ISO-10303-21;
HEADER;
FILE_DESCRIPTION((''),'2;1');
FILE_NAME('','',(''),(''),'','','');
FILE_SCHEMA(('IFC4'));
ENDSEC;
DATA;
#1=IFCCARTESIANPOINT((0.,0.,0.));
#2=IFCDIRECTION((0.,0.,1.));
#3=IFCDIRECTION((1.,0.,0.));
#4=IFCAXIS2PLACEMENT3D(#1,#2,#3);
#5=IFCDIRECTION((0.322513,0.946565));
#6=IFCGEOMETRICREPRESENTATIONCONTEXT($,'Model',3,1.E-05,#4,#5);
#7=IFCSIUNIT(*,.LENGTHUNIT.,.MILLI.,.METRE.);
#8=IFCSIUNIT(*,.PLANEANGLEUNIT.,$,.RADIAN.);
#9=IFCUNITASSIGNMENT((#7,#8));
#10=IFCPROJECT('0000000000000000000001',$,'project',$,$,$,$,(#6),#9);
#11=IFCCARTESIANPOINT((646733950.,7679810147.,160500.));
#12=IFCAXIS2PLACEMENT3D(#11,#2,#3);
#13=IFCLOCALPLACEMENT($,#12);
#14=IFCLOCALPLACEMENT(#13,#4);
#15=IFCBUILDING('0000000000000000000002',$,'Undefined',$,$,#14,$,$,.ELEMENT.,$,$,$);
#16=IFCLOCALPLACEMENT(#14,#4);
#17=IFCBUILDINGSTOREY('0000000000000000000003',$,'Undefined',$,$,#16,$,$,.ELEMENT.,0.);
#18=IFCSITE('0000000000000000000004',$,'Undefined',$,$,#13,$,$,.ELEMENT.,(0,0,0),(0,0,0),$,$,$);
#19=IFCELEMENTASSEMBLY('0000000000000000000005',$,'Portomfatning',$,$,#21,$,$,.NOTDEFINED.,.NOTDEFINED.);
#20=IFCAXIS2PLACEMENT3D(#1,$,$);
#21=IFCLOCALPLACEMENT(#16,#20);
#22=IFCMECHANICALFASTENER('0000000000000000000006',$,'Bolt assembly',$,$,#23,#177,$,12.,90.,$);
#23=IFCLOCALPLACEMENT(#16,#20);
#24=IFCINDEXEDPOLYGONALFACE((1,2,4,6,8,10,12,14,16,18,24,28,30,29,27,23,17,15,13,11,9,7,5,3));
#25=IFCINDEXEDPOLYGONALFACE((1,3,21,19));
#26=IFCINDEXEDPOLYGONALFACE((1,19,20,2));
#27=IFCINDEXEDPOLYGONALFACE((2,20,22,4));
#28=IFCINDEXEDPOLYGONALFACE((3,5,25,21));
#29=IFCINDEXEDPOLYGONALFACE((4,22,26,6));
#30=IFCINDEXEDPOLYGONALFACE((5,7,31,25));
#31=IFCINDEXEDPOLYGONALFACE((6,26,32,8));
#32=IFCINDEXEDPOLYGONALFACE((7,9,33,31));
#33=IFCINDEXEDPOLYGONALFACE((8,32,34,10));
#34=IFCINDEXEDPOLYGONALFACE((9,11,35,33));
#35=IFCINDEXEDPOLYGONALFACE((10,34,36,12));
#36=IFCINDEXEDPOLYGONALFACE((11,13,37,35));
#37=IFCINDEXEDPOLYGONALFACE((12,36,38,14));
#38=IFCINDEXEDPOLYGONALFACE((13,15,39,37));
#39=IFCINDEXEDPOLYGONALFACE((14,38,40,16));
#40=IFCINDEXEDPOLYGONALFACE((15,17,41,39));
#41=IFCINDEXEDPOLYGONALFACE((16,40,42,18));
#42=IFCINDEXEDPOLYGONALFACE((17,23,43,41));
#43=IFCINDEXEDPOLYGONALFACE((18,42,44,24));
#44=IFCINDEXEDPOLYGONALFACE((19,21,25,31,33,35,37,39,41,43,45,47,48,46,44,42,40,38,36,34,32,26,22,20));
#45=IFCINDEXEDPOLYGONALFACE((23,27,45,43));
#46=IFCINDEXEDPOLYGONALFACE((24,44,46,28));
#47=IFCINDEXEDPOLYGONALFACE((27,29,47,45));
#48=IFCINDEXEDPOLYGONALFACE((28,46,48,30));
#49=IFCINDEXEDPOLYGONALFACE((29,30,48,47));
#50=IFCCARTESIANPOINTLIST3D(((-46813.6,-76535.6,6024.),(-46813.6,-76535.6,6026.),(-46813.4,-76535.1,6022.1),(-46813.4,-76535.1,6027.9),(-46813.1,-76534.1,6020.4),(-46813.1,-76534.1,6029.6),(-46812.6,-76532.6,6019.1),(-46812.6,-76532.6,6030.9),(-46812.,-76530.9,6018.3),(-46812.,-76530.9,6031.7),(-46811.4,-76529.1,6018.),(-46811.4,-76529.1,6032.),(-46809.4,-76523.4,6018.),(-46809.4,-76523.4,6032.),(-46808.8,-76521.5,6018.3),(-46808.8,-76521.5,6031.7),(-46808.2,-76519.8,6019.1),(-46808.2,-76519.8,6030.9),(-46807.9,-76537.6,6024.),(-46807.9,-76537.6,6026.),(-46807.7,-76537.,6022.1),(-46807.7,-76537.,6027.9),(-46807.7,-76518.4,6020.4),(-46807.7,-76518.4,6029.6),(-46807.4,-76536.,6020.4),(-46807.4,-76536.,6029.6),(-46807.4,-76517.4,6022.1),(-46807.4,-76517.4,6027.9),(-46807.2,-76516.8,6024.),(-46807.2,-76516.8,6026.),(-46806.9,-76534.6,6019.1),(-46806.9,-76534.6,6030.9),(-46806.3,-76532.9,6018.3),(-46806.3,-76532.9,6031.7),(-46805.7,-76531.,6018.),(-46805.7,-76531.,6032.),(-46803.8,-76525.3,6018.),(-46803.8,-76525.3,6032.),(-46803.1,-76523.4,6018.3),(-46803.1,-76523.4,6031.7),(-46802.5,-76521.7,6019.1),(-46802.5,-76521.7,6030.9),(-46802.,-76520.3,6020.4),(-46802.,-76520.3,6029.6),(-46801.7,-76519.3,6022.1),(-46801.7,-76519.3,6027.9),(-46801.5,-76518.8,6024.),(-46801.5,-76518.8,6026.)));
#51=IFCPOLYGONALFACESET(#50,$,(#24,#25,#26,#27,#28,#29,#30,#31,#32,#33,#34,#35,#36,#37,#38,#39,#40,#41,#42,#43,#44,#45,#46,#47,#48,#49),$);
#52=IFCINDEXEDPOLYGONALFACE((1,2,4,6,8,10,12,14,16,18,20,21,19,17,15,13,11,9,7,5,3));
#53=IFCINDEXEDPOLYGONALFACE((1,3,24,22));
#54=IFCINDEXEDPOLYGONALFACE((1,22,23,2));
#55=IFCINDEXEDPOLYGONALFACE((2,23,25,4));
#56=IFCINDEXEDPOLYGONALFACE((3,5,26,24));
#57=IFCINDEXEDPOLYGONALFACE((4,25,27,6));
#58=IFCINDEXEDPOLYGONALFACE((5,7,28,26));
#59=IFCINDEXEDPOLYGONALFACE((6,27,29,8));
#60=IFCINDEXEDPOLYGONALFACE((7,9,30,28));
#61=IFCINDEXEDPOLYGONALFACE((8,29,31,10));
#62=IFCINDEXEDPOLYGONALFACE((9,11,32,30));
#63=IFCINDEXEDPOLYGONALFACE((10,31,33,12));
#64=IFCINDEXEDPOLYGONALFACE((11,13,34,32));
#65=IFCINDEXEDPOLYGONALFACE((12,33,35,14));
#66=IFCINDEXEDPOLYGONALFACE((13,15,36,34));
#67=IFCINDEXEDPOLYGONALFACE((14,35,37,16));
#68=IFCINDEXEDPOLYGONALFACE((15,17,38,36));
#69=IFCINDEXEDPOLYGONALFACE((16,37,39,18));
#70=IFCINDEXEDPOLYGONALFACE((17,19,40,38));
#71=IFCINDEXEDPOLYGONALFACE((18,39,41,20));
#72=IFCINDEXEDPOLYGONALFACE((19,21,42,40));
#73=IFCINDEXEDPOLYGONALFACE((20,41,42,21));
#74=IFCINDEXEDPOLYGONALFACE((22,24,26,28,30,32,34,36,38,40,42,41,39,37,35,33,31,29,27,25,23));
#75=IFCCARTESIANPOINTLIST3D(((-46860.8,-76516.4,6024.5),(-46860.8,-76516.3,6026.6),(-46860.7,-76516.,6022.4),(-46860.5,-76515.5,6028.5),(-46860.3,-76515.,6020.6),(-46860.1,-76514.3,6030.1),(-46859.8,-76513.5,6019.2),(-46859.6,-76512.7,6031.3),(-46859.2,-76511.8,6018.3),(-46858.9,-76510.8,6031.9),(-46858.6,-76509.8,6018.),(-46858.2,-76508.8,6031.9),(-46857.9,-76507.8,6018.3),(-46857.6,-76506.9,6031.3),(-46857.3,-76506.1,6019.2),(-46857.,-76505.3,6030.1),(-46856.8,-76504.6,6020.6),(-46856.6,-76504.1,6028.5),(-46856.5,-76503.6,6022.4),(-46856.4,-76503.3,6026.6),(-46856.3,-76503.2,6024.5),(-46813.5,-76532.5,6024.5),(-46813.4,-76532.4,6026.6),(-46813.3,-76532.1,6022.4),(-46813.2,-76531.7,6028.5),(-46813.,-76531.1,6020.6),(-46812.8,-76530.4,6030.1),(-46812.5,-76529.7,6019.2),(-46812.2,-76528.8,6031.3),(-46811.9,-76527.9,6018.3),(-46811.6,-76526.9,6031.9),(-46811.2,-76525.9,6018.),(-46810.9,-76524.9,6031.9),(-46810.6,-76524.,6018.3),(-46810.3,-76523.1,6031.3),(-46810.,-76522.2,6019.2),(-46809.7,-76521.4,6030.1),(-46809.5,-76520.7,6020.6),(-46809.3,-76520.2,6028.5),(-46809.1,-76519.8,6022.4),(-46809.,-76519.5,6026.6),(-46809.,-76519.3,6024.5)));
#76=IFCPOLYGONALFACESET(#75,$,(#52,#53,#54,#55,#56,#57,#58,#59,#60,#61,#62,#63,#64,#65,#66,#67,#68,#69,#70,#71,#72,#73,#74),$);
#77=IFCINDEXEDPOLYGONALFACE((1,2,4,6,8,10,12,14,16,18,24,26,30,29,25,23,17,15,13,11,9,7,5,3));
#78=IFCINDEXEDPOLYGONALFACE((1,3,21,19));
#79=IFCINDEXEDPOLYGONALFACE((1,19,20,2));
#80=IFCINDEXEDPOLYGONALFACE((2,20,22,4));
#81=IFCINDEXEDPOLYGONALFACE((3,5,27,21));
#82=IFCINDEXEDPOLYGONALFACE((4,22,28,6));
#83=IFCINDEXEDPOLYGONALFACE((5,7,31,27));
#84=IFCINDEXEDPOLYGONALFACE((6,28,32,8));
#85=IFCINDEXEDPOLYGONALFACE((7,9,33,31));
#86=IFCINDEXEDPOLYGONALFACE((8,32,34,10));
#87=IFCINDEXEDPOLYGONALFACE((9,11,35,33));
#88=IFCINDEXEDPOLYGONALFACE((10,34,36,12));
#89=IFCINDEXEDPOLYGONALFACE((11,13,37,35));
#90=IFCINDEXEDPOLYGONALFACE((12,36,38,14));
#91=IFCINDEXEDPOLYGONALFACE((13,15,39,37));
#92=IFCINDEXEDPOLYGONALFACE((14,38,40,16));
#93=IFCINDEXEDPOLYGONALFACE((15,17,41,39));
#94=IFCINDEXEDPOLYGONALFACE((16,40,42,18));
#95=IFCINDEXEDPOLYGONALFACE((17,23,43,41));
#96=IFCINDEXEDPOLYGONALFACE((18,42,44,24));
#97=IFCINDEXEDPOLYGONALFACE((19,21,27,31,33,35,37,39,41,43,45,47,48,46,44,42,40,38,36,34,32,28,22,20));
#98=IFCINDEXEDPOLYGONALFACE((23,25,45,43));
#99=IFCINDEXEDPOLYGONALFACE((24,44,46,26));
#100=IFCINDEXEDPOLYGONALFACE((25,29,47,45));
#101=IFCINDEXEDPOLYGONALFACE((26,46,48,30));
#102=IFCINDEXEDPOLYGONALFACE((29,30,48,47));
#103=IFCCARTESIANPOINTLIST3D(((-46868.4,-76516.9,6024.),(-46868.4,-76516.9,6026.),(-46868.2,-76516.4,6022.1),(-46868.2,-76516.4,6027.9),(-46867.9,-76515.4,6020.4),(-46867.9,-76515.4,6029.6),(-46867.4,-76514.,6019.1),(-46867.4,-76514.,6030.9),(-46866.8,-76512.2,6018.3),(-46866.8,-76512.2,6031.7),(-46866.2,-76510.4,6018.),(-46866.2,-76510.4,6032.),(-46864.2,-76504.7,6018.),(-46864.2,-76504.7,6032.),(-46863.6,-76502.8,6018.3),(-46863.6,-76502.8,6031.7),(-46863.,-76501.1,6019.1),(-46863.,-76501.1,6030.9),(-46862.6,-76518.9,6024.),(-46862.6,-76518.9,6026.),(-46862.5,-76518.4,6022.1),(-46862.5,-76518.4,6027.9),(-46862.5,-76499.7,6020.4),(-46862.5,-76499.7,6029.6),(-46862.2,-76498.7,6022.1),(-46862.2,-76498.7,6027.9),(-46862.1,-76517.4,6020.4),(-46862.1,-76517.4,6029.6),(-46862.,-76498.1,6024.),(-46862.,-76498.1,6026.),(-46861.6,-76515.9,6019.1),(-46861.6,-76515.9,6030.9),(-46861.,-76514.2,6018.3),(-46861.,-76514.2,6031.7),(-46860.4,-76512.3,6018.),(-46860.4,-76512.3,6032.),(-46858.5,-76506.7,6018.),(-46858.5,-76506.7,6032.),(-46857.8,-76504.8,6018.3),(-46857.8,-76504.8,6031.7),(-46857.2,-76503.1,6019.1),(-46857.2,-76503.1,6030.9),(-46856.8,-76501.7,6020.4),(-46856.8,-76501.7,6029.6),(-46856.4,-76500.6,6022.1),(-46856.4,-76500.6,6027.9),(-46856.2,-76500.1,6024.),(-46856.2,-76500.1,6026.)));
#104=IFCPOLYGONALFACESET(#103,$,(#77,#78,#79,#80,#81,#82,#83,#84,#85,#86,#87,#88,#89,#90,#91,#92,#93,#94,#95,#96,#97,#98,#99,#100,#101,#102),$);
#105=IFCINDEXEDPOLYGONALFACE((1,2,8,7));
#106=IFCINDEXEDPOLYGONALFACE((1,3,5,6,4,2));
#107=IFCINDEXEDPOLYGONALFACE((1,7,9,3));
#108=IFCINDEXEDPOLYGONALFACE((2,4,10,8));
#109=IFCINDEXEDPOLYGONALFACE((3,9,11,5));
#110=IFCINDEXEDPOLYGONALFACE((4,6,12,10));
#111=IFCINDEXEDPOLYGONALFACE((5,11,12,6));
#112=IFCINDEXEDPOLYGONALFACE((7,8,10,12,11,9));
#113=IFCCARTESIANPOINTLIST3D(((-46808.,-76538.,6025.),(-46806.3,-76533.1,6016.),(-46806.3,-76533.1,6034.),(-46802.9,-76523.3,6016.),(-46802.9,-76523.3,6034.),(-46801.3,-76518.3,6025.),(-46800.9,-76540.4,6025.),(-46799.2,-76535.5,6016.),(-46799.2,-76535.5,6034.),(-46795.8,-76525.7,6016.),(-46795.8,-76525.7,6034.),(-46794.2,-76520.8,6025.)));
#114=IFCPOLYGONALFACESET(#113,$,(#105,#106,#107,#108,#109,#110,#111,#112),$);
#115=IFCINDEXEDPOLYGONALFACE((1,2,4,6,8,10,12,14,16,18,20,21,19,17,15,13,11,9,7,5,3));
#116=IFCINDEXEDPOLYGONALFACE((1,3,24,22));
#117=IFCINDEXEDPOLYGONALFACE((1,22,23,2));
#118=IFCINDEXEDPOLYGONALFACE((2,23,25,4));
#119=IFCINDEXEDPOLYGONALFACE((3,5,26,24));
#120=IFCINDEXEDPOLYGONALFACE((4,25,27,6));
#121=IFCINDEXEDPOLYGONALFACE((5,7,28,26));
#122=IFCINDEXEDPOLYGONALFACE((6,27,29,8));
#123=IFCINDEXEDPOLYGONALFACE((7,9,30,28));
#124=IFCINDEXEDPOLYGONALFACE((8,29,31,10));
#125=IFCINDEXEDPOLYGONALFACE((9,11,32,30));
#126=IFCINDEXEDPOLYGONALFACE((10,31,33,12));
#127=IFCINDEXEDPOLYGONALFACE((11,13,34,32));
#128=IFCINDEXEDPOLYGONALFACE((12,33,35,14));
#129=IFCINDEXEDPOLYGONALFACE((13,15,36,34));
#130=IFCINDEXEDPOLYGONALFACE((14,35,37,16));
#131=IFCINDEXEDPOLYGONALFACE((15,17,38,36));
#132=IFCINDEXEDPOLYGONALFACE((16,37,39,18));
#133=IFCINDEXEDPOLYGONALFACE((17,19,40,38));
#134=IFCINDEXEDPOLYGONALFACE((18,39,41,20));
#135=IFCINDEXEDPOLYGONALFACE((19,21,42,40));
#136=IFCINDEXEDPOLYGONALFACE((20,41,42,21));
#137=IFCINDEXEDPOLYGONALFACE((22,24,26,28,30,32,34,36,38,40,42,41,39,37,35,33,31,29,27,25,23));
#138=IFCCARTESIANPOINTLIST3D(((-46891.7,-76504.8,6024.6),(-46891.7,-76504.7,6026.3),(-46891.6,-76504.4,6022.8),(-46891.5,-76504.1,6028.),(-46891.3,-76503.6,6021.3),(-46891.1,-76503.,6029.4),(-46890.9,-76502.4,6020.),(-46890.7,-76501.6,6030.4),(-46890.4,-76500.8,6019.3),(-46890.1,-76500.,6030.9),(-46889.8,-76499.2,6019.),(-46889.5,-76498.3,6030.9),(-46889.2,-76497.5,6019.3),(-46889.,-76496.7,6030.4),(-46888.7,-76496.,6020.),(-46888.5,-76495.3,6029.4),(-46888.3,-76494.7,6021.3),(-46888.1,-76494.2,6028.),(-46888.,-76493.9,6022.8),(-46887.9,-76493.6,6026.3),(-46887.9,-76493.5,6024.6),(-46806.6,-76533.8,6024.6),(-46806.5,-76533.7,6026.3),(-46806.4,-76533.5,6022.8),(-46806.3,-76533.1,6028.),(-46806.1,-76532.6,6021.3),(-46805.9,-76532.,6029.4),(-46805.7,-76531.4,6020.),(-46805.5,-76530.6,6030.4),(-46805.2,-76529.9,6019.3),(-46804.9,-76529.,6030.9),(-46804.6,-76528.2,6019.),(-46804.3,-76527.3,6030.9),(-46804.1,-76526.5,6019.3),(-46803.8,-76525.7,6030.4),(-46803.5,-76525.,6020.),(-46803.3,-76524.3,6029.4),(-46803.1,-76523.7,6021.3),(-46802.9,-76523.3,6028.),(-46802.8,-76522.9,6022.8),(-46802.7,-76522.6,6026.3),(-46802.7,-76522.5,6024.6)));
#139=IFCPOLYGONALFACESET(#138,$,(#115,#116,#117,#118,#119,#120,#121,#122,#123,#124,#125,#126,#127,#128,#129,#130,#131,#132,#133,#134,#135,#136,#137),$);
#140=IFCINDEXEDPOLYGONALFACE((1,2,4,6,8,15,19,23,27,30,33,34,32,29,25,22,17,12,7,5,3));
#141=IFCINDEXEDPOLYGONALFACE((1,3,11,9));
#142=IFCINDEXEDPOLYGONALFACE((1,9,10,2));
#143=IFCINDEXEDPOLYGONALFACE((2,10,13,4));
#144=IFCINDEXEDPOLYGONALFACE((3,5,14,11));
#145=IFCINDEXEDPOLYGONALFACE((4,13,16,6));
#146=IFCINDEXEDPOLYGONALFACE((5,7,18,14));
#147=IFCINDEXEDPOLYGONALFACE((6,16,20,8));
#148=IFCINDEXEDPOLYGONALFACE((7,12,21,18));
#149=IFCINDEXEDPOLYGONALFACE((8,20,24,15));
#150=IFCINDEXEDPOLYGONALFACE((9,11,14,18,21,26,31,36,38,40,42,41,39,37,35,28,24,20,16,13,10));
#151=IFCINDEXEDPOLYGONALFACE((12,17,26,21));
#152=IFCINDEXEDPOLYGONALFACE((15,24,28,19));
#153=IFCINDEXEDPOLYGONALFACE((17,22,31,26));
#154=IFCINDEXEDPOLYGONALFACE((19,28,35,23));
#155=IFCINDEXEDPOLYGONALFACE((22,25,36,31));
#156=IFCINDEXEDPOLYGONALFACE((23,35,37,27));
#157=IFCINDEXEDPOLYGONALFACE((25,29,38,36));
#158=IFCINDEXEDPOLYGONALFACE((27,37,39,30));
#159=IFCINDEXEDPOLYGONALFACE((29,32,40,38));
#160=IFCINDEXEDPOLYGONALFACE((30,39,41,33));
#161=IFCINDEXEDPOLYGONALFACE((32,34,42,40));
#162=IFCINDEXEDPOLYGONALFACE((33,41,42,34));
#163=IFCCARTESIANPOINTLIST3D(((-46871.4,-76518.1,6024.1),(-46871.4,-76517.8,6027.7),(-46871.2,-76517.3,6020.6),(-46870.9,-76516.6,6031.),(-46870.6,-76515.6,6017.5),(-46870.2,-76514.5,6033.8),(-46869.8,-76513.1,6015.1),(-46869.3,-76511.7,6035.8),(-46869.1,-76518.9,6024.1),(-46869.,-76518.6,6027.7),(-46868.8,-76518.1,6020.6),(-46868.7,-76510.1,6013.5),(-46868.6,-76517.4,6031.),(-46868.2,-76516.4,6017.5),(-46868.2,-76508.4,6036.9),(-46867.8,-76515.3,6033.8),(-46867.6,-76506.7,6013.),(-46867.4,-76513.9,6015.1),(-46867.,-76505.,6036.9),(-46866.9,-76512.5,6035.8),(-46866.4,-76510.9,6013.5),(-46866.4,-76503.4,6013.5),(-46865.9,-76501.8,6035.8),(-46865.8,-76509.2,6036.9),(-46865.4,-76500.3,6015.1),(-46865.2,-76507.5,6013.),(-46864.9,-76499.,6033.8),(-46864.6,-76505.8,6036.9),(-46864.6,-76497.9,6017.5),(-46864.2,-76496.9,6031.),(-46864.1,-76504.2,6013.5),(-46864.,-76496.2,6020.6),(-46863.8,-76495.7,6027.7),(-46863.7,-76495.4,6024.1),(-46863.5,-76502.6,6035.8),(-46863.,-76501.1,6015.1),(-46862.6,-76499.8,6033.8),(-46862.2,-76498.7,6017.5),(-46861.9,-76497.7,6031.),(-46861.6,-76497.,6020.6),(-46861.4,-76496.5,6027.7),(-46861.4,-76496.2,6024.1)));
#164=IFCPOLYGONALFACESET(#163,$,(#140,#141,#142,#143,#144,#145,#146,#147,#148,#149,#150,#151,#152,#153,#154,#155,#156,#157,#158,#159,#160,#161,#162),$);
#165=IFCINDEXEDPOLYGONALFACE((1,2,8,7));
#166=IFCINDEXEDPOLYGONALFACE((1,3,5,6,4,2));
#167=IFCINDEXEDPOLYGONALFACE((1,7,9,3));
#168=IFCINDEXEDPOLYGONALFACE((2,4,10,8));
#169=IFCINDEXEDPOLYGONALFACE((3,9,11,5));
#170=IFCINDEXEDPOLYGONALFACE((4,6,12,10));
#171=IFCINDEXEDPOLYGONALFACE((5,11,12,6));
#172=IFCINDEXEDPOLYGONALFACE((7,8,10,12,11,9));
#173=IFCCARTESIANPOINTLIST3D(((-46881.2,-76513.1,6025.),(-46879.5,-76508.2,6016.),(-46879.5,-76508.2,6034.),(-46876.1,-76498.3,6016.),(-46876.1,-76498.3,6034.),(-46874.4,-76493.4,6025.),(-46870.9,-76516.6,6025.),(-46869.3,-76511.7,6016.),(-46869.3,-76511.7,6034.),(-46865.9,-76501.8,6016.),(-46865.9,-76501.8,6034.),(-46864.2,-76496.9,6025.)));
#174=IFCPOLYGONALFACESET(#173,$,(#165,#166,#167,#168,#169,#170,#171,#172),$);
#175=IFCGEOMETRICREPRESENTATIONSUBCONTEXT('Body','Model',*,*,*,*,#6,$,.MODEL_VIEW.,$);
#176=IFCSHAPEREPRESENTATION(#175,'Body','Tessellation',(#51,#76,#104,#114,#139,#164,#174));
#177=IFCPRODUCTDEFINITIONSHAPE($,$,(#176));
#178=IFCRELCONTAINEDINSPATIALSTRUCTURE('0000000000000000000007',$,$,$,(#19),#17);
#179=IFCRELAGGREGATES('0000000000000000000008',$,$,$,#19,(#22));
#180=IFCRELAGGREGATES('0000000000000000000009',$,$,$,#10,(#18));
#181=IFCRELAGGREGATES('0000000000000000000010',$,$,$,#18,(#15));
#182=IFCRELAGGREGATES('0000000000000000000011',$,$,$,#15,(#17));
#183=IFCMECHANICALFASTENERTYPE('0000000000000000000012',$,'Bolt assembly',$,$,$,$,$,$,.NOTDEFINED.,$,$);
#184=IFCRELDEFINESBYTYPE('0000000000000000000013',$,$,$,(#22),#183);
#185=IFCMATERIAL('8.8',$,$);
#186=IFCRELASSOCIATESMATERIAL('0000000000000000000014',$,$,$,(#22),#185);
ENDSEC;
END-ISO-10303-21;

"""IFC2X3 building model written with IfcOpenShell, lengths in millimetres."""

from ifc_helpers import new_model, entity, si_unit, direction, frame, origin_with_axes, origin_2d_with_axis, place, context, subcontext, project, spatial, polyline, circle, outline, extrude, source, transform, mapped, material, type_object, element, aggregate, save


model = new_model("IFC2X3")

# Units and contexts
model_context = context("Model", 3, precision=1e-05, world=origin_with_axes(), true_north=direction((0.322513, 0.946565)))
body_context = subcontext(model_context, "Body", "Model", "MODEL_VIEW")
ifc_project = project(units=[si_unit("LENGTHUNIT", "METRE", prefix="MILLI"), si_unit("PLANEANGLEUNIT", "RADIAN")], contexts=[model_context])

# Site, building, storey
site_placement = place(None, frame((646733950.0, 7679810147.0, 160500.0), z_axis=(0.0, 0.0, 1.0), x_axis=(1.0, 0.0, 0.0)))
site = spatial("IfcSite", under=ifc_project, at=site_placement, Name="Undefined", CompositionType="ELEMENT", RefLatitude=(0, 0, 0), RefLongitude=(0, 0, 0))
building_placement = place(site_placement, origin_with_axes())
building = spatial("IfcBuilding", under=site, at=building_placement, Name="Undefined", CompositionType="ELEMENT")
storey_placement = place(building_placement, origin_with_axes())
storey = spatial("IfcBuildingStorey", under=building, at=storey_placement, Name="Undefined", CompositionType="ELEMENT", Elevation=0.0)

# Shared definitions
ifc_material_1 = material(Name="8.8")
mechanical_fastener_type = type_object("IfcMechanicalFastenerType", Name="Bolt assembly")

# Element assembly, mechanical fastener
shared_circle_1 = entity("IfcCircle", entity("IfcAxis2Placement2D", entity("IfcCartesianPoint", [0.0, -3.0]), entity("IfcDirection", [1.0, 0.0])), 7.0)
shared_circle_2 = entity("IfcCircle", entity("IfcAxis2Placement2D", entity("IfcCartesianPoint", [0.0, 3.0]), entity("IfcDirection", [-1.0, 0.0])), 7.0)
shared_composite_curve = entity("IfcCompositeCurve", [entity("IfcCompositeCurveSegment", "CONTINUOUS", True, entity("IfcPolyline", [entity("IfcCartesianPoint", [7.0, 3.0]), entity("IfcCartesianPoint", [7.0, -3.0])])), entity("IfcCompositeCurveSegment", "CONTINUOUS", True, entity("IfcTrimmedCurve", shared_circle_1, [entity("IfcParameterValue", 0.0)], [entity("IfcParameterValue", 3.141593)], False, "PARAMETER")), entity("IfcCompositeCurveSegment", "CONTINUOUS", True, entity("IfcPolyline", [entity("IfcCartesianPoint", [-7.0, -3.0]), entity("IfcCartesianPoint", [-7.0, 3.0])])), entity("IfcCompositeCurveSegment", "DISCONTINUOUS", True, entity("IfcTrimmedCurve", shared_circle_2, [entity("IfcParameterValue", 0.0)], [entity("IfcParameterValue", 3.141593)], False, "PARAMETER"))], False)
assembly_1_placement = place(storey_placement, origin_with_axes())
assembly_1 = element("IfcElementAssembly", 1, at=assembly_1_placement, inside=storey, Name="Portomfatning", AssemblyPlace="NOTDEFINED", PredefinedType="NOTDEFINED")
shared_shape_1 = source(origin_with_axes(), body_context, "Body", "SweptSolid", [
    entity("IfcExtrudedAreaSolid", entity("IfcArbitraryClosedProfileDef", "AREA", None, shared_composite_curve), entity("IfcAxis2Placement3D", entity("IfcCartesianPoint", [0.0, 5.1, 0.0]), entity("IfcDirection", [0.0, 1.0, 0.0]), entity("IfcDirection", [1.0, 0.0, 0.0])), entity("IfcDirection", [0.0, 0.0, 1.0]), 6.0),
    extrude(circle(Radius=7.0, at=origin_2d_with_axis()), frame((0.0, 12.0, 0.0), z_axis=(0.0, 1.0, 0.0), x_axis=(1.0, 0.0, 0.0)), (0.0, 0.0, 1.0), 50.0),
    entity("IfcExtrudedAreaSolid", entity("IfcArbitraryClosedProfileDef", "AREA", None, shared_composite_curve), entity("IfcAxis2Placement3D", entity("IfcCartesianPoint", [0.0, 62.9, 0.0]), entity("IfcDirection", [0.0, 1.0, 0.0]), entity("IfcDirection", [1.0, 0.0, 0.0])), entity("IfcDirection", [0.0, 0.0, 1.0]), 6.1),
    extrude(outline(polyline([(9.0, -5.2), (9.0, 5.2), (0.0, 10.4), (-9.0, 5.2), (-9.0, -5.2), (0.0, -10.4), (9.0, -5.2)])), frame((0.0, -2.5, 0.0), z_axis=(0.0, 1.0, 0.0), x_axis=(1.0, 0.0, 0.0)), (0.0, 0.0, 1.0), 7.5),
    extrude(circle(Radius=6.0, at=origin_2d_with_axis()), frame((0.0, 5.0, 0.0), z_axis=(0.0, 1.0, 0.0), x_axis=(1.0, 0.0, 0.0)), (0.0, 0.0, 1.0), 90.0),
    extrude(circle(Radius=12.0, at=origin_2d_with_axis()), frame((0.0, 69.0, 0.0), z_axis=(0.0, 1.0, 0.0), x_axis=(1.0, 0.0, 0.0)), (0.0, 0.0, 1.0), 2.5),
    extrude(outline(polyline([(9.0, -5.2), (9.0, 5.2), (0.0, 10.4), (-9.0, 5.2), (-9.0, -5.2), (0.0, -10.4), (9.0, -5.2)])), frame((0.0, 71.5, 0.0), z_axis=(0.0, 1.0, 0.0), x_axis=(1.0, 0.0, 0.0)), (0.0, 0.0, 1.0), 10.8),
])
mechanical_fastener_1_placement = place(assembly_1_placement, frame((-46799.9, -76529.8, 6025.0), z_axis=(0.322513, 0.946565, 0.0), x_axis=(0.0, 0.0, -1.0)))
mechanical_fastener_1 = element("IfcMechanicalFastener", 2, at=mechanical_fastener_1_placement, type_object=mechanical_fastener_type, material=ifc_material_1, Name="Bolt assembly", NominalDiameter=12.0, NominalLength=90.0, context=body_context, shape_type="MappedRepresentation", body=[
    mapped(shared_shape_1, transform((0.0, 0.0, 0.0))),
])
aggregate(assembly_1, [mechanical_fastener_1])

save(model, "model.ifc")
